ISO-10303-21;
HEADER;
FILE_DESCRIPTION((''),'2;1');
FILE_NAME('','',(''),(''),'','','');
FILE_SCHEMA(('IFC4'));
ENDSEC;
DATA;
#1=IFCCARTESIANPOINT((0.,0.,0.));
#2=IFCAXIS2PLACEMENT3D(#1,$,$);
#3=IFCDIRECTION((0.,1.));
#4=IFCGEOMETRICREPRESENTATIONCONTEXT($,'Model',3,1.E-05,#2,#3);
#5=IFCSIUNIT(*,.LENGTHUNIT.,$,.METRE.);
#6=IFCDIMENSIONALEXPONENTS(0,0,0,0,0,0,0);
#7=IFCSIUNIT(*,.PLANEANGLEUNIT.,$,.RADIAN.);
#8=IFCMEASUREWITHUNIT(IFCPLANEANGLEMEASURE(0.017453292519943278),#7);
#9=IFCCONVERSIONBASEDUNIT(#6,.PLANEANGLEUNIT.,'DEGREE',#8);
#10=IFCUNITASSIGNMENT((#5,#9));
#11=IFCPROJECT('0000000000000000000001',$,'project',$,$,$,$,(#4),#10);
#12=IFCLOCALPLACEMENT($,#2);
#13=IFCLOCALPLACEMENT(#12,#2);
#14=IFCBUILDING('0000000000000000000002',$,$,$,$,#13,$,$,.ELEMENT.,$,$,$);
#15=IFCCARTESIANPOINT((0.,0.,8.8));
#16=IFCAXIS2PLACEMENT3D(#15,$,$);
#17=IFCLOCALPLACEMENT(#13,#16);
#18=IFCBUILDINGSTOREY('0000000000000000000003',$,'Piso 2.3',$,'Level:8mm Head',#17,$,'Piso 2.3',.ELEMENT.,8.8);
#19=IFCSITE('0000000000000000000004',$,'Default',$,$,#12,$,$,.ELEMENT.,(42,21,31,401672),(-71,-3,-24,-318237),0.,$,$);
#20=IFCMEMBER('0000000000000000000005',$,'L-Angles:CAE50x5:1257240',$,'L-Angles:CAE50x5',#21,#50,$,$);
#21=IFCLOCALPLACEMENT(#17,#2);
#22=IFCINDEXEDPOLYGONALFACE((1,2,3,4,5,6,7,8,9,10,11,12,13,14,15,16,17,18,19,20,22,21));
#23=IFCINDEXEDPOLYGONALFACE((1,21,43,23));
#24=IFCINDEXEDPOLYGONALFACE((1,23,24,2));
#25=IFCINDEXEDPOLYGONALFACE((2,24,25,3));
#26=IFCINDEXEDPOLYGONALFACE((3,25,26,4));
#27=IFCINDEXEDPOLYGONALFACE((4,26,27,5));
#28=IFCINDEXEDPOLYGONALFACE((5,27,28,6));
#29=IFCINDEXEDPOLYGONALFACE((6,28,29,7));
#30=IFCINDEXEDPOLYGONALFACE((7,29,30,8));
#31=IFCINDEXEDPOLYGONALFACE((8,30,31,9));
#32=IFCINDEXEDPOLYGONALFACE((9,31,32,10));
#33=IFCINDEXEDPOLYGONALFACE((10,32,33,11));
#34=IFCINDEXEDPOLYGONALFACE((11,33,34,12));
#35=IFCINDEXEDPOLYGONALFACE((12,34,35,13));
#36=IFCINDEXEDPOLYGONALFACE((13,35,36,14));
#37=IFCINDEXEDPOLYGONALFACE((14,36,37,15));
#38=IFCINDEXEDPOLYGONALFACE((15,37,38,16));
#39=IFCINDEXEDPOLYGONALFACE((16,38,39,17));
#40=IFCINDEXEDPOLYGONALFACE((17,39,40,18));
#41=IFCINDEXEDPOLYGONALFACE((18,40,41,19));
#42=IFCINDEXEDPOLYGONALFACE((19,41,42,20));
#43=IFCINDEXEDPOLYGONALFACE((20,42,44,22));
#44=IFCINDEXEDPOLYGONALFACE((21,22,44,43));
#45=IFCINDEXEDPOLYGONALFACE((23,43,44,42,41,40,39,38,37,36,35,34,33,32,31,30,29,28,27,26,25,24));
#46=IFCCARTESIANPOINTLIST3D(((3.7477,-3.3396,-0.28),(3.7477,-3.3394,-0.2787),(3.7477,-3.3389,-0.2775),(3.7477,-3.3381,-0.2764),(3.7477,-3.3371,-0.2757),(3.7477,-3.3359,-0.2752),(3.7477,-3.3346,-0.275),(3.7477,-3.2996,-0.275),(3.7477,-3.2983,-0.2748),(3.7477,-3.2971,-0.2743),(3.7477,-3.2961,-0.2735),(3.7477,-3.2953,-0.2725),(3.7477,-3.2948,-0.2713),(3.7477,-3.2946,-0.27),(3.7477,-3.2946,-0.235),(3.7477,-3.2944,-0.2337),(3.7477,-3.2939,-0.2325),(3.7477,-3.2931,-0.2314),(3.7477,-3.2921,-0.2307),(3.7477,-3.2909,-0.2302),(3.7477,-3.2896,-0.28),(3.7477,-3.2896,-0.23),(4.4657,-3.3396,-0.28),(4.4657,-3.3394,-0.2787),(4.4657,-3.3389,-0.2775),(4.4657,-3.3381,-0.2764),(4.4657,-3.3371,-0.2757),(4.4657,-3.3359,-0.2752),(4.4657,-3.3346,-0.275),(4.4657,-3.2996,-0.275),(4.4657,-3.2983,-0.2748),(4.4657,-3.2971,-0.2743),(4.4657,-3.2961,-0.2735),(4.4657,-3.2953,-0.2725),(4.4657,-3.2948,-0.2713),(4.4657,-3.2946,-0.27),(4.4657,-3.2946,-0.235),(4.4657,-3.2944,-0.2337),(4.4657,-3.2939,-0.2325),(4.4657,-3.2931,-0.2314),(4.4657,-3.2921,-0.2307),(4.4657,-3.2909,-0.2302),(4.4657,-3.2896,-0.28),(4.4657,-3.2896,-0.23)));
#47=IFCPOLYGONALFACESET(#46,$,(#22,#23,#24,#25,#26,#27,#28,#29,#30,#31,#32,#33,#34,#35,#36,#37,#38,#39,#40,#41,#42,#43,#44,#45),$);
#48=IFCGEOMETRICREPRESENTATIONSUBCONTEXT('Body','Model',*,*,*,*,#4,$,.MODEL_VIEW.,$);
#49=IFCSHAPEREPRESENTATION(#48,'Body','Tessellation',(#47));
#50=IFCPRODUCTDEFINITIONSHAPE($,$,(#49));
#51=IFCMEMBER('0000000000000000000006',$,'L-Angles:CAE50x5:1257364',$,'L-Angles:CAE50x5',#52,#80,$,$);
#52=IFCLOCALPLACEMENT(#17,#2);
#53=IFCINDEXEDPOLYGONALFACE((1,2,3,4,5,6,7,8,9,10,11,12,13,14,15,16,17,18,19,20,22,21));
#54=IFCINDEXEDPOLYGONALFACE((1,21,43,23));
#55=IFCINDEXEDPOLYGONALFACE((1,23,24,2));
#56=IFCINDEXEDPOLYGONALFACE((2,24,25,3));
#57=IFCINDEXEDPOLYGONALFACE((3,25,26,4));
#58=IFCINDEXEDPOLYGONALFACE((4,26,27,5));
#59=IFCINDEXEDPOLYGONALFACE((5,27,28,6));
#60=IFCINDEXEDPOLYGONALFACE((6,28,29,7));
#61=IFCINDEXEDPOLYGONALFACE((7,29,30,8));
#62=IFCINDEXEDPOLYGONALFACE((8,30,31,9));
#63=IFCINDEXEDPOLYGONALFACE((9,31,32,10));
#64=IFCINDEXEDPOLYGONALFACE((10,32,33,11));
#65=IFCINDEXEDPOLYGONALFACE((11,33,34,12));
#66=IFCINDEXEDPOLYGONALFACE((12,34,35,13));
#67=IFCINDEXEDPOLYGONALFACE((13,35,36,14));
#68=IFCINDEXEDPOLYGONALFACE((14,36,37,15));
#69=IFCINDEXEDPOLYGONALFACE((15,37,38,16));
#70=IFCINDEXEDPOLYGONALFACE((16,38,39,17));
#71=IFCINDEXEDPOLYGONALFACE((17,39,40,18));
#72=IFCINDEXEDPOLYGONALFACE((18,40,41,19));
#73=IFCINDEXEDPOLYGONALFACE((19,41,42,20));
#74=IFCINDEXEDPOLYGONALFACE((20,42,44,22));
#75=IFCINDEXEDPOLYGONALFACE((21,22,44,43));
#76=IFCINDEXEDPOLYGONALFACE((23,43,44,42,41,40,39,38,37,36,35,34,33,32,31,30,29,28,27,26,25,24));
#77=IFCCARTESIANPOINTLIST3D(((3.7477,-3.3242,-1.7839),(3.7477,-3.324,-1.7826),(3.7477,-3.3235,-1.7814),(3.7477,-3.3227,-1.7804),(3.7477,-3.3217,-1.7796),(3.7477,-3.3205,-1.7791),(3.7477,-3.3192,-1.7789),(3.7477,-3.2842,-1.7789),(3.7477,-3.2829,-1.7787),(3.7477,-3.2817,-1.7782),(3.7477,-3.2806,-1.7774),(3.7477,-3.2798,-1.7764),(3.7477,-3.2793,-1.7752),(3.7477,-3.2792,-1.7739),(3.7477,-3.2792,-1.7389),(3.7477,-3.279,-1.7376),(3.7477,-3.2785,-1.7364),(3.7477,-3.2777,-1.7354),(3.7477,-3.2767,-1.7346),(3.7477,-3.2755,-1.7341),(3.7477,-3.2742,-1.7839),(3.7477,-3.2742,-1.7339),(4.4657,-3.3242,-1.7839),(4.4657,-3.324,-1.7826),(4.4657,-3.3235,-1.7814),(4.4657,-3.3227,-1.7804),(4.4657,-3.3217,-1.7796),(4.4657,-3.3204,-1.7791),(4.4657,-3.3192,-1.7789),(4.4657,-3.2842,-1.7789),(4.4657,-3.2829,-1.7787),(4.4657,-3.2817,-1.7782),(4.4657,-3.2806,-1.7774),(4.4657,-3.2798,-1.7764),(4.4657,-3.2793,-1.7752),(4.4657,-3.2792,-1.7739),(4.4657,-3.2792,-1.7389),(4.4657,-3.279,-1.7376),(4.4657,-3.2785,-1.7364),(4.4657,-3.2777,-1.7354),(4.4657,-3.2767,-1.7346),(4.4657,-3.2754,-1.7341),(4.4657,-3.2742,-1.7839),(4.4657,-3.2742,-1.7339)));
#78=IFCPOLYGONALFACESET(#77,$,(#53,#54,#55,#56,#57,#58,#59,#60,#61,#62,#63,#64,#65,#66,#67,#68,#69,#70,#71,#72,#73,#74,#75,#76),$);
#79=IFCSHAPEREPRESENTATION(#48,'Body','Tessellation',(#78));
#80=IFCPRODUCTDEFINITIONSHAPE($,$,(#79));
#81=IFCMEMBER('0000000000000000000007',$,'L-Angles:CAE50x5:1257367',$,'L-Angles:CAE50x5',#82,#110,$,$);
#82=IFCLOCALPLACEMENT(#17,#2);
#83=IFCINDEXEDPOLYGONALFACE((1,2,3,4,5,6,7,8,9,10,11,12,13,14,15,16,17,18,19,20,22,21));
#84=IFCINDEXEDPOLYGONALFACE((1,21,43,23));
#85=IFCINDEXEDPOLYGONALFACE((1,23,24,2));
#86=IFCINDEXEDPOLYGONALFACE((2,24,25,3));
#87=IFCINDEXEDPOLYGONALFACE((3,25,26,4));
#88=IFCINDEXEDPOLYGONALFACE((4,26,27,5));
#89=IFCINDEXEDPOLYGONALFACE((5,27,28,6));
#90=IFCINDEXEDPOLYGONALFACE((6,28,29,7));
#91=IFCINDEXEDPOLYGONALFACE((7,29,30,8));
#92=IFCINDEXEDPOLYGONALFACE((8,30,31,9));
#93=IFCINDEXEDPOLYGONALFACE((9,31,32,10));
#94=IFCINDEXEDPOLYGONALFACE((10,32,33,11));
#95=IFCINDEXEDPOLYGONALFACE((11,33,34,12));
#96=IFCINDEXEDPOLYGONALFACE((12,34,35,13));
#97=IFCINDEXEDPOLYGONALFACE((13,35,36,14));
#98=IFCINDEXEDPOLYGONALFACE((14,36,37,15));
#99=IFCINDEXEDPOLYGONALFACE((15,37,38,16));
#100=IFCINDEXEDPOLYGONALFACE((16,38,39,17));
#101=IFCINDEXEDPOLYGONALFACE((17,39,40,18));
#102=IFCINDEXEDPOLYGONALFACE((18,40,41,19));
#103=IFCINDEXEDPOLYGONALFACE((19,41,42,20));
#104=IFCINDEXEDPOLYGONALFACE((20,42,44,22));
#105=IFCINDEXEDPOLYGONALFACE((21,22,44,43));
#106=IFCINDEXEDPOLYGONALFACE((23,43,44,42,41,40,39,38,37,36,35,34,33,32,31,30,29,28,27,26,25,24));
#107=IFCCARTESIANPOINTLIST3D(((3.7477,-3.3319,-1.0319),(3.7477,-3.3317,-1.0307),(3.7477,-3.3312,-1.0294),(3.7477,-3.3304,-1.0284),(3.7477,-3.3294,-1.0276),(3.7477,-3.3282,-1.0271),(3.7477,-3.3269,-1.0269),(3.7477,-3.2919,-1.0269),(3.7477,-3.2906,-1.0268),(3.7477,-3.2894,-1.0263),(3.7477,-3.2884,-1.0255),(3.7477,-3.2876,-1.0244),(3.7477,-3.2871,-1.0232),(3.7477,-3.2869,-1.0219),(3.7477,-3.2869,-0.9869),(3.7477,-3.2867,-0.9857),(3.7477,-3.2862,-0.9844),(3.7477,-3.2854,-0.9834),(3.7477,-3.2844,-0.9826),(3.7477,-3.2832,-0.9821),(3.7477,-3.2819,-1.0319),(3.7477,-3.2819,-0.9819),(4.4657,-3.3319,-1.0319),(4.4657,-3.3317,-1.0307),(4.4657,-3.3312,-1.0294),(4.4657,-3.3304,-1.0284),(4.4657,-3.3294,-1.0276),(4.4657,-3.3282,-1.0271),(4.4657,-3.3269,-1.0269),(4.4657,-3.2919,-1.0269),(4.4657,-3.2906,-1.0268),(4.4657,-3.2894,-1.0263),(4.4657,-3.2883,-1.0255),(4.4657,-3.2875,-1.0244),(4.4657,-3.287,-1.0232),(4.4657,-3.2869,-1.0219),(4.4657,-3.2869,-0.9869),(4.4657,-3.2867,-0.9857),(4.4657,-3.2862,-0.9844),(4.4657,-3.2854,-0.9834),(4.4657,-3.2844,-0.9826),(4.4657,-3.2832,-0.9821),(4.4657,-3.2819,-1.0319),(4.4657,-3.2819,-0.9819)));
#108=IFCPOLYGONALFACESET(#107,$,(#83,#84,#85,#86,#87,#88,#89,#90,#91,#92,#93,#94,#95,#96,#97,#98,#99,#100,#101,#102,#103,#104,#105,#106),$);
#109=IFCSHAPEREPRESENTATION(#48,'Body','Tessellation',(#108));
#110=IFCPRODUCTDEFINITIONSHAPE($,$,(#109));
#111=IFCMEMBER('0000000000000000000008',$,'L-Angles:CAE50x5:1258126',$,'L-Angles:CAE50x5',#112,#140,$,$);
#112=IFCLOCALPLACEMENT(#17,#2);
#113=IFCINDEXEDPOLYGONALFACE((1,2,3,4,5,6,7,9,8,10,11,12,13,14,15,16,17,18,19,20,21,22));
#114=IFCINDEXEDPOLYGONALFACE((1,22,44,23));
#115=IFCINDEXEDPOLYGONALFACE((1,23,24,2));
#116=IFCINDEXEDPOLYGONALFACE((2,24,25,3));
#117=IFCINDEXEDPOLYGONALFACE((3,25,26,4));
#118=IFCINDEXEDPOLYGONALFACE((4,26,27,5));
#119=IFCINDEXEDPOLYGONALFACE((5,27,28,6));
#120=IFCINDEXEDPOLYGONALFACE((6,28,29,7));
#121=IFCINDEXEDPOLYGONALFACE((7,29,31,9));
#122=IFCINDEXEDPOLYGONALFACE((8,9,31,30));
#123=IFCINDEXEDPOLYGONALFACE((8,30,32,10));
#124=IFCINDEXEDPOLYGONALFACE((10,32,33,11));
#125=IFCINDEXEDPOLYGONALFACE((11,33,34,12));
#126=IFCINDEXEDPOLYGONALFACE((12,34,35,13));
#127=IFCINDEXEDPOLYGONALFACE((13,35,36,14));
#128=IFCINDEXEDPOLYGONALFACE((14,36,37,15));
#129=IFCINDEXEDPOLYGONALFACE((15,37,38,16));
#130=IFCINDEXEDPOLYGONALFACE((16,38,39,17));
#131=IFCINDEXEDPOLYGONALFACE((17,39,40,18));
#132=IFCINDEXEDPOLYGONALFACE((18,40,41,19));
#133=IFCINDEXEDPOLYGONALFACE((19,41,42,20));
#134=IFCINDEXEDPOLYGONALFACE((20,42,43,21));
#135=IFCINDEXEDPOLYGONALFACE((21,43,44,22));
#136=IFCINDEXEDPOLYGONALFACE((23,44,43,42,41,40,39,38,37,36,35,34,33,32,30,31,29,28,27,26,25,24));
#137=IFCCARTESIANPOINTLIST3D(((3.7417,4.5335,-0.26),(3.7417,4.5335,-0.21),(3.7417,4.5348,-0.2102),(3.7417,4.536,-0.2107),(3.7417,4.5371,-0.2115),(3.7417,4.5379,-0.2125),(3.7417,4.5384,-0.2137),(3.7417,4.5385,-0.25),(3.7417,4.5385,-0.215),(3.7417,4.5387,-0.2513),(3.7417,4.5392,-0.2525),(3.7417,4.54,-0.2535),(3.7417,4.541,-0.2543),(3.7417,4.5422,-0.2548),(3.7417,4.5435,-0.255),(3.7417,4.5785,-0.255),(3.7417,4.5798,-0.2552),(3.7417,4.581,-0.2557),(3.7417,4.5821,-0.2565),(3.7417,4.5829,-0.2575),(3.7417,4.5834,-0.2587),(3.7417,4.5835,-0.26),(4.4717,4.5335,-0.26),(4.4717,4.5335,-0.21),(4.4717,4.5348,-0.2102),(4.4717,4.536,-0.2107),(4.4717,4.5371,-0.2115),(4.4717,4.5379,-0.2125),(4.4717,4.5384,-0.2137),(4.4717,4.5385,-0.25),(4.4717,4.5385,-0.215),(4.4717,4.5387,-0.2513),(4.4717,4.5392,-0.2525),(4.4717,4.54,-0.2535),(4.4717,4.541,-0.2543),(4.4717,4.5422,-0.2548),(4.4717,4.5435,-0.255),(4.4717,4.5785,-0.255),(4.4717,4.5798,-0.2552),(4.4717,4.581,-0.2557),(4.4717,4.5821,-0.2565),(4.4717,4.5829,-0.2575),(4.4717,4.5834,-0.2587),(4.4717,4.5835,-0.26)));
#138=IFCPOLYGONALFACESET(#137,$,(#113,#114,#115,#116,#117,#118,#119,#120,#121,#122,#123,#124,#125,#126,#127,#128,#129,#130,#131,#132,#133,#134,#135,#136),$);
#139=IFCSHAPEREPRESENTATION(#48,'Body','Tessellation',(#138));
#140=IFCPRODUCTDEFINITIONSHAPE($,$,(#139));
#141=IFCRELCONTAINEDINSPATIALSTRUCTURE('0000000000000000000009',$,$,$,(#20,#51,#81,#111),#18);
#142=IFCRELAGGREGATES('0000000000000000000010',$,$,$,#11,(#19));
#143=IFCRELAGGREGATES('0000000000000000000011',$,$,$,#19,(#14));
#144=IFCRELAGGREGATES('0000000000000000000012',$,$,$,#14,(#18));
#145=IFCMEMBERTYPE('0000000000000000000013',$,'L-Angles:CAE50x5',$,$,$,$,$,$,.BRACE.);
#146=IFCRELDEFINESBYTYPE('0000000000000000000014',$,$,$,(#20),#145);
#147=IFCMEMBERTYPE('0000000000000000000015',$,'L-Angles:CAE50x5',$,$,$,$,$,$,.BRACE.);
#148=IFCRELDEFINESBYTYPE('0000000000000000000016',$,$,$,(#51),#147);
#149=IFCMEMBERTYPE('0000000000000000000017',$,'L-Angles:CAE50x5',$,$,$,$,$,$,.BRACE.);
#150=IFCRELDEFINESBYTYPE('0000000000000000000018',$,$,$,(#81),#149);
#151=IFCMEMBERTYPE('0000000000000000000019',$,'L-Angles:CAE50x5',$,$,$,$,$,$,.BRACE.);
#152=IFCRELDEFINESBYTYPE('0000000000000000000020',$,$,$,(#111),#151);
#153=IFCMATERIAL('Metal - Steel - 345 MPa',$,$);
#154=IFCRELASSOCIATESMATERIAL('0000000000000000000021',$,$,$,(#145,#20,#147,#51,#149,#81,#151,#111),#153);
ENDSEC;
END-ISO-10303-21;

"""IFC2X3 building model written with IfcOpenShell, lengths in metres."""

from ifc_helpers import new_model, entity, si_unit, converted_unit, direction, frame, frame_2d, origin, place, context, subcontext, project, spatial, polyline, circle_curve, parameter, trimmed, segment, composite_curve, outline, extrude, source, transform, mapped, material, type_object, type_shapes, element, save


model = new_model("IFC2X3")

# Units and contexts
model_context = context("Model", 3, precision=1e-05, world=origin(), true_north=direction((0.0, 1.0)))
body_context = subcontext(model_context, "Body", "Model", "MODEL_VIEW")
ifc_project = project(units=[si_unit("LENGTHUNIT", "METRE"), converted_unit("PLANEANGLEUNIT", "DEGREE", entity("IfcPlaneAngleMeasure", 0.017453292519943278), si_unit("PLANEANGLEUNIT", "RADIAN"), dimensions=[0, 0, 0, 0, 0, 0, 0])], contexts=[model_context])

# Site, building, storey
site_placement = place(None, origin())
site = spatial("IfcSite", under=ifc_project, at=site_placement, Name="Default", CompositionType="ELEMENT", RefLatitude=(42, 21, 31, 401672), RefLongitude=(-71, -3, -24, -318237), RefElevation=0.0)
building_placement = place(site_placement, origin())
building = spatial("IfcBuilding", under=site, at=building_placement, CompositionType="ELEMENT")
storey_placement = place(building_placement, frame((0.0, 0.0, 8.8)))
storey = spatial("IfcBuildingStorey", under=building, at=storey_placement, Name="Piso 2.3", ObjectType="Level:8mm Head", LongName="Piso 2.3", CompositionType="ELEMENT", Elevation=8.8)

# Shared definitions
ifc_material_1 = material(Name="Metal - Steel - 345 MPa")

# Members
member_type_1 = type_object("IfcMemberType", Name="L-Angles:CAE50x5", PredefinedType="BRACE", material=ifc_material_1)
shared_shape_1 = source(origin(), body_context, "Body", "SweptSolid", [
    extrude(outline(composite_curve([segment(polyline([(-0.0164, -0.0164), (0.0336, -0.0164)]), True, "CONTINUOUS"), segment(trimmed(circle_curve(frame_2d((0.0286, -0.0164), x_axis=(1.0, 0.0)), 0.005), [parameter(0.0)], [parameter(90.0)], True, "PARAMETER"), True, "CONTINUOUS"), segment(polyline([(0.0286, -0.0114), (-0.0064, -0.0114)]), True, "CONTINUOUS"), segment(trimmed(circle_curve(frame_2d((-0.0064, -0.0064), x_axis=(1.0, 0.0)), 0.005), [parameter(180.0)], [parameter(270.0)], True, "PARAMETER"), False, "CONTINUOUS"), segment(polyline([(-0.0114, -0.0064), (-0.0114, 0.0286)]), True, "CONTINUOUS"), segment(trimmed(circle_curve(frame_2d((-0.0164, 0.0286), x_axis=(1.0, 0.0)), 0.005), [parameter(0.0)], [parameter(90.0)], True, "PARAMETER"), True, "CONTINUOUS"), segment(polyline([(-0.0164, 0.0336), (-0.0164, -0.0164)]), True, "CONTINUOUS")], self_intersect=False)), frame((-0.359, -0.0024, -0.0024), z_axis=(1.0, 0.0, 0.0), x_axis=(0.0, -1.0, 0.0)), (0.0, 0.0, 1.0), 0.718),
])
type_shapes(member_type_1, [shared_shape_1])
member_1_placement = place(storey_placement, frame((4.1067, -3.3036, -0.266), z_axis=(-0.000006, 1.0, 0.0), x_axis=(1.0, 0.000006, 0.0)))
element("IfcMember", 1, at=member_1_placement, inside=storey, type_object=member_type_1, material=ifc_material_1, Name="L-Angles:CAE50x5:1257240", ObjectType="L-Angles:CAE50x5", context=body_context, shape_type="MappedRepresentation", body=[
    mapped(shared_shape_1, transform((0.0, 0.0, 0.0), scale=1.0)),
])
member_type_2 = type_object("IfcMemberType", Name="L-Angles:CAE50x5", PredefinedType="BRACE", material=ifc_material_1)
shared_shape_2 = source(origin(), body_context, "Body", "SweptSolid", [
    extrude(outline(composite_curve([segment(polyline([(-0.0164, -0.0164), (0.0336, -0.0164)]), True, "CONTINUOUS"), segment(trimmed(circle_curve(frame_2d((0.0286, -0.0164), x_axis=(1.0, 0.0)), 0.005), [parameter(0.0)], [parameter(90.0)], True, "PARAMETER"), True, "CONTINUOUS"), segment(polyline([(0.0286, -0.0114), (-0.0064, -0.0114)]), True, "CONTINUOUS"), segment(trimmed(circle_curve(frame_2d((-0.0064, -0.0064), x_axis=(1.0, 0.0)), 0.005), [parameter(180.0)], [parameter(270.0)], True, "PARAMETER"), False, "CONTINUOUS"), segment(polyline([(-0.0114, -0.0064), (-0.0114, 0.0286)]), True, "CONTINUOUS"), segment(trimmed(circle_curve(frame_2d((-0.0164, 0.0286), x_axis=(1.0, 0.0)), 0.005), [parameter(0.0)], [parameter(90.0)], True, "PARAMETER"), True, "CONTINUOUS"), segment(polyline([(-0.0164, 0.0336), (-0.0164, -0.0164)]), True, "CONTINUOUS")], self_intersect=False)), frame((-0.359, -0.0024, -0.0024), z_axis=(1.0, 0.0, 0.0), x_axis=(0.0, -1.0, 0.0)), (0.0, 0.0, 1.0), 0.718),
])
type_shapes(member_type_2, [shared_shape_2])
member_2_placement = place(storey_placement, frame((4.1067, -3.2882, -1.7699), z_axis=(-0.000041, 1.0, 0.0), x_axis=(1.0, 0.000041, 0.0)))
element("IfcMember", 2, at=member_2_placement, inside=storey, type_object=member_type_2, material=ifc_material_1, Name="L-Angles:CAE50x5:1257364", ObjectType="L-Angles:CAE50x5", context=body_context, shape_type="MappedRepresentation", body=[
    mapped(shared_shape_2, transform((0.0, 0.0, 0.0), scale=1.0)),
])
member_type_3 = type_object("IfcMemberType", Name="L-Angles:CAE50x5", PredefinedType="BRACE", material=ifc_material_1)
shared_shape_3 = source(origin(), body_context, "Body", "SweptSolid", [
    extrude(outline(composite_curve([segment(polyline([(-0.0164, -0.0164), (0.0336, -0.0164)]), True, "CONTINUOUS"), segment(trimmed(circle_curve(frame_2d((0.0286, -0.0164), x_axis=(1.0, 0.0)), 0.005), [parameter(0.0)], [parameter(90.0)], True, "PARAMETER"), True, "CONTINUOUS"), segment(polyline([(0.0286, -0.0114), (-0.0064, -0.0114)]), True, "CONTINUOUS"), segment(trimmed(circle_curve(frame_2d((-0.0064, -0.0064), x_axis=(1.0, 0.0)), 0.005), [parameter(180.0)], [parameter(270.0)], True, "PARAMETER"), False, "CONTINUOUS"), segment(polyline([(-0.0114, -0.0064), (-0.0114, 0.0286)]), True, "CONTINUOUS"), segment(trimmed(circle_curve(frame_2d((-0.0164, 0.0286), x_axis=(1.0, 0.0)), 0.005), [parameter(0.0)], [parameter(90.0)], True, "PARAMETER"), True, "CONTINUOUS"), segment(polyline([(-0.0164, 0.0336), (-0.0164, -0.0164)]), True, "CONTINUOUS")], self_intersect=False)), frame((-0.359, -0.0024, -0.0024), z_axis=(1.0, 0.0, 0.0), x_axis=(0.0, -1.0, 0.0)), (0.0, 0.0, 1.0), 0.718),
])
type_shapes(member_type_3, [shared_shape_3])
member_3_placement = place(storey_placement, frame((4.1067, -3.2959, -1.0179), z_axis=(-0.000024, 1.0, 0.0), x_axis=(1.0, 0.000024, 0.0)))
element("IfcMember", 3, at=member_3_placement, inside=storey, type_object=member_type_3, material=ifc_material_1, Name="L-Angles:CAE50x5:1257367", ObjectType="L-Angles:CAE50x5", context=body_context, shape_type="MappedRepresentation", body=[
    mapped(shared_shape_3, transform((0.0, 0.0, 0.0), scale=1.0)),
])
member_type_4 = type_object("IfcMemberType", Name="L-Angles:CAE50x5", PredefinedType="BRACE", material=ifc_material_1)
shared_shape_4 = source(origin(), body_context, "Body", "SweptSolid", [
    extrude(outline(composite_curve([segment(polyline([(-0.0164, -0.0164), (0.0336, -0.0164)]), True, "CONTINUOUS"), segment(trimmed(circle_curve(frame_2d((0.0286, -0.0164), x_axis=(1.0, 0.0)), 0.005), [parameter(0.0)], [parameter(90.0)], True, "PARAMETER"), True, "CONTINUOUS"), segment(polyline([(0.0286, -0.0114), (-0.0064, -0.0114)]), True, "CONTINUOUS"), segment(trimmed(circle_curve(frame_2d((-0.0064, -0.0064), x_axis=(1.0, 0.0)), 0.005), [parameter(180.0)], [parameter(270.0)], True, "PARAMETER"), False, "CONTINUOUS"), segment(polyline([(-0.0114, -0.0064), (-0.0114, 0.0286)]), True, "CONTINUOUS"), segment(trimmed(circle_curve(frame_2d((-0.0164, 0.0286), x_axis=(1.0, 0.0)), 0.005), [parameter(0.0)], [parameter(90.0)], True, "PARAMETER"), True, "CONTINUOUS"), segment(polyline([(-0.0164, 0.0336), (-0.0164, -0.0164)]), True, "CONTINUOUS")], self_intersect=False)), frame((-0.365, -0.0024, -0.0024), z_axis=(1.0, 0.0, 0.0), x_axis=(0.0, -1.0, 0.0)), (0.0, 0.0, 1.0), 0.73),
])
type_shapes(member_type_4, [shared_shape_4])
for number, where, z_axis, x_axis, name in (
    (4, (4.1067, 4.5475, -0.246), (0.0, -1.0, 0.0), (-1.0, 0.0, 0.0), "L-Angles:CAE50x5:1258126"),
):
    element("IfcMember", number, at=place(storey_placement, frame(where, z_axis=z_axis, x_axis=x_axis)), inside=storey, type_object=member_type_4, material=ifc_material_1, Name=name, ObjectType="L-Angles:CAE50x5", context=body_context, shape_type="MappedRepresentation", body=[
        mapped(shared_shape_4, transform((0.0, 0.0, 0.0), scale=1.0)),
    ])

save(model, "model.ifc")
